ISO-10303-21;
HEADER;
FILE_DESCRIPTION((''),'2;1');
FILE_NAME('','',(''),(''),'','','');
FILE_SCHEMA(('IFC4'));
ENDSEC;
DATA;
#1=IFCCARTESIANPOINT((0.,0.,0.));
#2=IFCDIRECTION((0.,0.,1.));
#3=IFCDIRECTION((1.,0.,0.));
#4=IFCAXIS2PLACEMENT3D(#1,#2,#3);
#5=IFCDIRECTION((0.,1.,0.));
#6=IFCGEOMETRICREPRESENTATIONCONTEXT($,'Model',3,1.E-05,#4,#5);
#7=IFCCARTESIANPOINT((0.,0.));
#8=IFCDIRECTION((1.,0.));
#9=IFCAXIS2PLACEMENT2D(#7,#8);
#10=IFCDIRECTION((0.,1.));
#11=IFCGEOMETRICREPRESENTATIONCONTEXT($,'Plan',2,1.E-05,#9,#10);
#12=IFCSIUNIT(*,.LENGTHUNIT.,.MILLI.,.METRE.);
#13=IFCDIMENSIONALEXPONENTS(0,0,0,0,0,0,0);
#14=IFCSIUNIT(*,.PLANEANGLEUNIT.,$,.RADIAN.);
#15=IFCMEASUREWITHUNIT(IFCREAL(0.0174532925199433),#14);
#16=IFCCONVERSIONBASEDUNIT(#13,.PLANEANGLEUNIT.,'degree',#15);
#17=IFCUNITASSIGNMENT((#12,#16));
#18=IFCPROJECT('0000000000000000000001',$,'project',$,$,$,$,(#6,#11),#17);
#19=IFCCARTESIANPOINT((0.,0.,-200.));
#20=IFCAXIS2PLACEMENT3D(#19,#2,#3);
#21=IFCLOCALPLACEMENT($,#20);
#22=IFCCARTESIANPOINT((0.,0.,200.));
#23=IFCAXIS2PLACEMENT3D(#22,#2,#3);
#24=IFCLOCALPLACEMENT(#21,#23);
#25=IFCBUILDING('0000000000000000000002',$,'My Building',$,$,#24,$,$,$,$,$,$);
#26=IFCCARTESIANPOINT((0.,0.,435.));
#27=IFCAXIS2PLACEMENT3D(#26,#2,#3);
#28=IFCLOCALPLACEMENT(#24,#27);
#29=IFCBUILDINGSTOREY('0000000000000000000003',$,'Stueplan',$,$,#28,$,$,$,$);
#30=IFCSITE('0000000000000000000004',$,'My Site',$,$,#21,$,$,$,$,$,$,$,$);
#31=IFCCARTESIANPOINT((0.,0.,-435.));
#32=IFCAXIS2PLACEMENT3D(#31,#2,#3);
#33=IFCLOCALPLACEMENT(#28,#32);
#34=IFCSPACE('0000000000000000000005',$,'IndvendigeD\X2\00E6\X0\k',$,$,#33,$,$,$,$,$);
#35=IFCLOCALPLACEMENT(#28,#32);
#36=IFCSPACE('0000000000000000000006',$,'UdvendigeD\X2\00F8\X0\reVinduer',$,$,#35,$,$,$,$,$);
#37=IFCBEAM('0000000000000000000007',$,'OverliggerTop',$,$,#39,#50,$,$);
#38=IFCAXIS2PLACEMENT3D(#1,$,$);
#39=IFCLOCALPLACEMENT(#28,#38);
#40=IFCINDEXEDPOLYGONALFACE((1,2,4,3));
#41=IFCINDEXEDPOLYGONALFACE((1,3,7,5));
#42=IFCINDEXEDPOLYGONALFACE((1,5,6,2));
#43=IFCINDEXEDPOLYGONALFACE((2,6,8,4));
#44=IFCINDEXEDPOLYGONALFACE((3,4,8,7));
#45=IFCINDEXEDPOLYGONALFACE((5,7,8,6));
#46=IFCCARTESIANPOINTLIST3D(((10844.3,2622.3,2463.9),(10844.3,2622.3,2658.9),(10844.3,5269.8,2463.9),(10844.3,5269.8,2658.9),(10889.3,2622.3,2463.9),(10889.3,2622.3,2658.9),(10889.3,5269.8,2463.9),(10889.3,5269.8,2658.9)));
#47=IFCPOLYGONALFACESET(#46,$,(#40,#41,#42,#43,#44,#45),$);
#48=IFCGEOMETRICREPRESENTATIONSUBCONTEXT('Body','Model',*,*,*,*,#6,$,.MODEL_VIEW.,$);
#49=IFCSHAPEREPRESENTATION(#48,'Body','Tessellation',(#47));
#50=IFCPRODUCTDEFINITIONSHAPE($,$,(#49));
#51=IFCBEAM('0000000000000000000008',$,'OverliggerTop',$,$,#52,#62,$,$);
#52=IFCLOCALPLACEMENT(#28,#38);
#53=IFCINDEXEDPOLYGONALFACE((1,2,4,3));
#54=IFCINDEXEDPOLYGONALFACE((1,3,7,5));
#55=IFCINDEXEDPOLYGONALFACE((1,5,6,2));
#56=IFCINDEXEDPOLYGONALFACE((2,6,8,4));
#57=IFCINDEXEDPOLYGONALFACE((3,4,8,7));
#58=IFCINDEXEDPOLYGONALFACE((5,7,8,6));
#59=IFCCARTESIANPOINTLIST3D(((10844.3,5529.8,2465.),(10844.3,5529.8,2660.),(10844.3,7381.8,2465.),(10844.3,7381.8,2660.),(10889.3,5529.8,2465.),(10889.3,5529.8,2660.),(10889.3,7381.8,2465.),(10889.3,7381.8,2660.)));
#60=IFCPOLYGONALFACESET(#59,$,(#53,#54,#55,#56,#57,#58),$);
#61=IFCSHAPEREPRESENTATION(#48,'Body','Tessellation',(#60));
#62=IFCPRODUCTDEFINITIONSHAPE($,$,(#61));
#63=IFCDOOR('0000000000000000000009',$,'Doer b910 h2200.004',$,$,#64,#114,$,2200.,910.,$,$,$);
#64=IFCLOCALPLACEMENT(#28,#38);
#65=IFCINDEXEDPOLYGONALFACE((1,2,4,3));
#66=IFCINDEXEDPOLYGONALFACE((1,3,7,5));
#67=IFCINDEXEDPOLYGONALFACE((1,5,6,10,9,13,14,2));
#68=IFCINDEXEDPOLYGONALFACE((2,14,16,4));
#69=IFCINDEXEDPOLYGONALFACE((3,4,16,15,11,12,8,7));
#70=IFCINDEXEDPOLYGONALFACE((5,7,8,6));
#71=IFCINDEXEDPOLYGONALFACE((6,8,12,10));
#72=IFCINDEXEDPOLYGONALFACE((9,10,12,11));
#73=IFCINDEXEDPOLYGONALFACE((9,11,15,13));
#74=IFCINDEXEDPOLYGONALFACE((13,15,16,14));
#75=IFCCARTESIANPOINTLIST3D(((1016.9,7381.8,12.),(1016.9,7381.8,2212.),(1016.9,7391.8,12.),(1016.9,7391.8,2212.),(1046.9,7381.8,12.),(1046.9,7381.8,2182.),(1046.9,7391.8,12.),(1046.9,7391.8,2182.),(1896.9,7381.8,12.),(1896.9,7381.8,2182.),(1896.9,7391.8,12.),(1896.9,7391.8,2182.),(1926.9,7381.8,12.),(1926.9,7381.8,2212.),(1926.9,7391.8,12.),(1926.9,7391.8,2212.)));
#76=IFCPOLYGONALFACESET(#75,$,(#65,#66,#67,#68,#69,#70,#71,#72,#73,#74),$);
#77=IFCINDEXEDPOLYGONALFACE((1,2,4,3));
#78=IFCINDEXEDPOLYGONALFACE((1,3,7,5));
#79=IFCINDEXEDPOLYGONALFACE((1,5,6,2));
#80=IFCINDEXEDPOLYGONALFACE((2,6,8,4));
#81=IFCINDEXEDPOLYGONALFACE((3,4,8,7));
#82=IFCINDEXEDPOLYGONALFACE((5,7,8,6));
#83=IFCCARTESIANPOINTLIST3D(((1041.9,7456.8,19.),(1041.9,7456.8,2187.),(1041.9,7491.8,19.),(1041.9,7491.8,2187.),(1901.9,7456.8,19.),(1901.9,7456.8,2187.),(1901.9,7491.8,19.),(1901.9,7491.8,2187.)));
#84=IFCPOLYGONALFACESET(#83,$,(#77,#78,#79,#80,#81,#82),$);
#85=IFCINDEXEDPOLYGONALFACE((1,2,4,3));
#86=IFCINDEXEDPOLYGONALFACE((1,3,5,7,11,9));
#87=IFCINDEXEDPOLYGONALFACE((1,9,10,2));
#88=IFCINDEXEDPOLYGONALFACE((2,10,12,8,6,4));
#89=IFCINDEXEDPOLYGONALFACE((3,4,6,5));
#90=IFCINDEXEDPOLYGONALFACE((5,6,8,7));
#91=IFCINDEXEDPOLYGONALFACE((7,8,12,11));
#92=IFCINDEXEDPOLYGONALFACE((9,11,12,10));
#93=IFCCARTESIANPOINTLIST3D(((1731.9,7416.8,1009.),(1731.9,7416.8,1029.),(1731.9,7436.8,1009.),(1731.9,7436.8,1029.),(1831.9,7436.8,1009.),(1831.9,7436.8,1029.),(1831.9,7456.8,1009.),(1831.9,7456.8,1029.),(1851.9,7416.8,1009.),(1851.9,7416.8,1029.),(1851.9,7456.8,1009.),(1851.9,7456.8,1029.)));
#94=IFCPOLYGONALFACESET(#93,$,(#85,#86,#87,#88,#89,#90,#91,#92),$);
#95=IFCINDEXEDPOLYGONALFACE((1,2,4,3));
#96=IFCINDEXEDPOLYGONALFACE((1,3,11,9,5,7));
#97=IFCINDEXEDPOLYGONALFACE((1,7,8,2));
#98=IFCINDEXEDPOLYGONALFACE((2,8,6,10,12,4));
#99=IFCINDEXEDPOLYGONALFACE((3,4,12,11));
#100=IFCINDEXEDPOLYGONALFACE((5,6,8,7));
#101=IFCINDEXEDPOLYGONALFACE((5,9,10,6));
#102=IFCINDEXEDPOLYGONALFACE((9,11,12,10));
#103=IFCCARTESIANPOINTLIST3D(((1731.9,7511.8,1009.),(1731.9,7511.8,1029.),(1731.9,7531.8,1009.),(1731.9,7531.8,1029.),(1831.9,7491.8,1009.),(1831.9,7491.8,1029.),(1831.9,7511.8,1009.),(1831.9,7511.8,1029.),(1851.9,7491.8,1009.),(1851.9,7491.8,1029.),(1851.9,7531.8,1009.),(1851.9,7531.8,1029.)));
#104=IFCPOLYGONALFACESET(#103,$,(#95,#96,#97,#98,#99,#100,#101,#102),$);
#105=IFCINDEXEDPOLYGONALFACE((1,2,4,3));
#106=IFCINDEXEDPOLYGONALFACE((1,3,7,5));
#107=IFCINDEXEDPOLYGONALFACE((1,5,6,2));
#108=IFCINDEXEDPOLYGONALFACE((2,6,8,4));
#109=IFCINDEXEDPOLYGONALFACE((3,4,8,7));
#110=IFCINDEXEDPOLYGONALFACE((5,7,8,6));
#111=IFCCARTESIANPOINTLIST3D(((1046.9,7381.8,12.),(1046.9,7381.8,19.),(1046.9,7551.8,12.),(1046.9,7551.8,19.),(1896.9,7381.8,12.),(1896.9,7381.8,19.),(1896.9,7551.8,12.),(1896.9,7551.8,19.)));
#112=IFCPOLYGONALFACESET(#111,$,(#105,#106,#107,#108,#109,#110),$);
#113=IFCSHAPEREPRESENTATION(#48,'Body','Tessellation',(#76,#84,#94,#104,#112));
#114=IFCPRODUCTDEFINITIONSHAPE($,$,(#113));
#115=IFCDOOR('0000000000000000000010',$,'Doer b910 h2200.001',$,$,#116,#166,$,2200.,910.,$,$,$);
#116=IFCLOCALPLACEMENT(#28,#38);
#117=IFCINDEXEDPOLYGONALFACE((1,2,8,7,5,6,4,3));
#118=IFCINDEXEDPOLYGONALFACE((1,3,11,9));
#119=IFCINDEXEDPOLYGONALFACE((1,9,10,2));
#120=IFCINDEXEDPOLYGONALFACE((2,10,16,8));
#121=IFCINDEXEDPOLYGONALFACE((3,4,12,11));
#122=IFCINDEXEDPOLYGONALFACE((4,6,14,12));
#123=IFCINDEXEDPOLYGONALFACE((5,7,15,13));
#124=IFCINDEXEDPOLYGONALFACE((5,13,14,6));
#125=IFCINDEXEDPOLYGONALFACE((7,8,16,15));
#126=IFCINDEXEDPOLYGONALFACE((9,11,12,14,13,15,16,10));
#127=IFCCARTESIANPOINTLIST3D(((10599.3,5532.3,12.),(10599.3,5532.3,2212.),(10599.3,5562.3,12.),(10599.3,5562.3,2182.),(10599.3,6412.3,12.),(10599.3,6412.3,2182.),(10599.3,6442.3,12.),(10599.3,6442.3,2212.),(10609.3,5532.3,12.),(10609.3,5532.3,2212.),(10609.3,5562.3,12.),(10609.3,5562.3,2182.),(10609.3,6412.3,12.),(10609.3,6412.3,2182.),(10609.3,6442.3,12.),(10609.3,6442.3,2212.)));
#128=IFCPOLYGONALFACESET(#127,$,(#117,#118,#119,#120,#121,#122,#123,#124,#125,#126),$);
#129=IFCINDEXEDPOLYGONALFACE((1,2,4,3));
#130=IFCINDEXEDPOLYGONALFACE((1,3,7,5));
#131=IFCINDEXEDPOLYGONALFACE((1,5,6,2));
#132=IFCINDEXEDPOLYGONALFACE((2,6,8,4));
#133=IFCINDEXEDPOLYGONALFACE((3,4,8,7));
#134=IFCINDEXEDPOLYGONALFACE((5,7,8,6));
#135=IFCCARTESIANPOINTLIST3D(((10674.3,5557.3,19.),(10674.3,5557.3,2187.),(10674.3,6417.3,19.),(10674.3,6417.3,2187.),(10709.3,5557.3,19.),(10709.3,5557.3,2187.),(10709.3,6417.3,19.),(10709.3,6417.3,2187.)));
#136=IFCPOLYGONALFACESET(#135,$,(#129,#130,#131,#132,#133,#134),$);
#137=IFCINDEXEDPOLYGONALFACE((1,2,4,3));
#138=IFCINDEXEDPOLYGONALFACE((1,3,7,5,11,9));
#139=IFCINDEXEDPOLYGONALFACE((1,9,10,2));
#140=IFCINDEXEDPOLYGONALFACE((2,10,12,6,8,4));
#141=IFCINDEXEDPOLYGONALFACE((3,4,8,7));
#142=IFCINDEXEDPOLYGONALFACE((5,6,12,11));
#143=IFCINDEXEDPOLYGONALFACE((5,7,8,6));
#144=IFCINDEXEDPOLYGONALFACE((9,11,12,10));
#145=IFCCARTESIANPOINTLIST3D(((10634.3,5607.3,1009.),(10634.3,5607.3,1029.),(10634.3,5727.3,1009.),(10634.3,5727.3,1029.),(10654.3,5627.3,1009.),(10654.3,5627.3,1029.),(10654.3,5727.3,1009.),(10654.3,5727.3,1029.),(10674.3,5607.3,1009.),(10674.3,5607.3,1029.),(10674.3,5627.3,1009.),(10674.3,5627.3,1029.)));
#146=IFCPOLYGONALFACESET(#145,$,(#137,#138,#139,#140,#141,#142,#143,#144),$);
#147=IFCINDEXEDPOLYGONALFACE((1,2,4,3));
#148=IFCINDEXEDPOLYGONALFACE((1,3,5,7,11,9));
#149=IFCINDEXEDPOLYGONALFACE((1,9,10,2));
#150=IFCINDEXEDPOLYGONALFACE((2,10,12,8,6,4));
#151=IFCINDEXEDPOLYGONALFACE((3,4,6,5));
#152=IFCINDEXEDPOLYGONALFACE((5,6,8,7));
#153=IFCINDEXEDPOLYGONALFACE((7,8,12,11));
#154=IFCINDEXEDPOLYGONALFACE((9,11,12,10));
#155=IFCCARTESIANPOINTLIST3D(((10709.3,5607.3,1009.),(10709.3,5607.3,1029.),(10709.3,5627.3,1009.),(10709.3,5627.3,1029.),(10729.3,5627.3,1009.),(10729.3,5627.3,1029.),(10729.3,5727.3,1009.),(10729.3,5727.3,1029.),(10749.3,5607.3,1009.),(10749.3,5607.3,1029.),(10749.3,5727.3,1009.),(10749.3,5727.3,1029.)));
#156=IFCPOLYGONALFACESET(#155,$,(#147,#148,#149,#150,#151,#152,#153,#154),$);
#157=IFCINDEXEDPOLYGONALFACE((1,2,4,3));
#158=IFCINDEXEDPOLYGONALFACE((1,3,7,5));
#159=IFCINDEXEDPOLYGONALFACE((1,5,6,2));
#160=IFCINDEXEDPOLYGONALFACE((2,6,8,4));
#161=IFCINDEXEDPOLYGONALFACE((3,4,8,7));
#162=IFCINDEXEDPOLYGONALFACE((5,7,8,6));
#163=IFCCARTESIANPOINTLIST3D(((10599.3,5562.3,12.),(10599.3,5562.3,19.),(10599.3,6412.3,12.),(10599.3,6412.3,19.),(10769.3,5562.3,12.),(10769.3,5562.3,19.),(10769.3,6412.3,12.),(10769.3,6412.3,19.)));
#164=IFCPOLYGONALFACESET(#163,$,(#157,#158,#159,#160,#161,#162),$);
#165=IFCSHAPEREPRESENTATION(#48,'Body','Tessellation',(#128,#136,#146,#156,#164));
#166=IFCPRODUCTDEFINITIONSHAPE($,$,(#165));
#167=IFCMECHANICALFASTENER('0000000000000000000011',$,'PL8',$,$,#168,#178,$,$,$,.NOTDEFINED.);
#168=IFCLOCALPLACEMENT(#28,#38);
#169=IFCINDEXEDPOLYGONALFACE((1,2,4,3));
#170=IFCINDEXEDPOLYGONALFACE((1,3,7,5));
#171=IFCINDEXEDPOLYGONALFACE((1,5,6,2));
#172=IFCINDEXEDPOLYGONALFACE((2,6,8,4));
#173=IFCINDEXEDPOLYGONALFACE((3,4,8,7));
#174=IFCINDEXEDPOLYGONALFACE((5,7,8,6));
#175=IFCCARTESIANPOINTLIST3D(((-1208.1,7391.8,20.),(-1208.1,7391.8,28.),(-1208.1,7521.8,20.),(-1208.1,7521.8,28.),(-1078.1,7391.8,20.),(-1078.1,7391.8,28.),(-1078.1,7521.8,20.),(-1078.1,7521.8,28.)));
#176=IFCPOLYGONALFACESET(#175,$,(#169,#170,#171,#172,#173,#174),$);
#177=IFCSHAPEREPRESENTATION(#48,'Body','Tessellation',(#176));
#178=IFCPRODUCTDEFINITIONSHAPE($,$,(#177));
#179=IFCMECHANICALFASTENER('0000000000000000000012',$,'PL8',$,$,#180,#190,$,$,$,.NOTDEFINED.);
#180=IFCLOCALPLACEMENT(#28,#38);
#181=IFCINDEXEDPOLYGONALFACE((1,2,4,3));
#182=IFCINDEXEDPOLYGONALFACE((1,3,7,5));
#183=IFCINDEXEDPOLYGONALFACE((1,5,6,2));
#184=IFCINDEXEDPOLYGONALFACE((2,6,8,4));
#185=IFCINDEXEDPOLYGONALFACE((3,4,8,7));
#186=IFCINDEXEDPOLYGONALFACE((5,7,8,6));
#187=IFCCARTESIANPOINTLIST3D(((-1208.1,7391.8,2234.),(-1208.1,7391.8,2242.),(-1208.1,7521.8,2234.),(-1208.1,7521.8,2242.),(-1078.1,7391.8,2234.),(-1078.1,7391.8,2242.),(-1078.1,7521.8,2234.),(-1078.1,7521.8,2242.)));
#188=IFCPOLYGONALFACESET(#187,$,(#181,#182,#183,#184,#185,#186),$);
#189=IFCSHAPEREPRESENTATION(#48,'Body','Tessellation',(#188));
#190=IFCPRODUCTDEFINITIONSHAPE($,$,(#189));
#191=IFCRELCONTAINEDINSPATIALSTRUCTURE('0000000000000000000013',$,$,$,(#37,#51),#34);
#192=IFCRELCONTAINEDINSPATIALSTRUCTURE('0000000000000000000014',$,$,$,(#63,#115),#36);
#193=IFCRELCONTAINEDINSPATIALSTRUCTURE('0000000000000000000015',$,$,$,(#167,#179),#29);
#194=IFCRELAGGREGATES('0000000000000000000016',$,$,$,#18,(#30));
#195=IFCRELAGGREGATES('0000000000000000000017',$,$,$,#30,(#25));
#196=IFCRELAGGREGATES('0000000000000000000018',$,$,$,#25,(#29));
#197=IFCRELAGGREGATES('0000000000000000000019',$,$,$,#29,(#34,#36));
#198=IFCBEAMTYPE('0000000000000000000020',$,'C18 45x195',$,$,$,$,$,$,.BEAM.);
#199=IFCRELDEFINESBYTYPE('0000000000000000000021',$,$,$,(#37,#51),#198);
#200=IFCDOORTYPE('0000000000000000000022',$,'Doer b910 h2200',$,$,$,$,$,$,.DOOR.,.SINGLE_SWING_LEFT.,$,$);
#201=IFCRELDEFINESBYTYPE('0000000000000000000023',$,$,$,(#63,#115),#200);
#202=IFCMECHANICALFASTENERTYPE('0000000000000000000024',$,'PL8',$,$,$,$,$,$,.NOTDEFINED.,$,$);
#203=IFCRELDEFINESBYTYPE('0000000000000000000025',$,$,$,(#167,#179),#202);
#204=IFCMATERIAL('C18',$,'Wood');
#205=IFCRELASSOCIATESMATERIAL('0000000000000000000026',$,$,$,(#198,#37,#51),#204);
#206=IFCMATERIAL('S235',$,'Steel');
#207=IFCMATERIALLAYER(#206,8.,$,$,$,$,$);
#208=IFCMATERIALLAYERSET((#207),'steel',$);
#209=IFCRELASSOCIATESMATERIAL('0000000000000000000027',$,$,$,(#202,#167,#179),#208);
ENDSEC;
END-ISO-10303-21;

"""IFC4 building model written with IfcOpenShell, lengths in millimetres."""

from ifc_helpers import new_model, entity, si_unit, converted_unit, direction, frame, origin_with_axes, origin_2d_with_axis, place, context, subcontext, project, spatial, line, indexed_curve, rectangle, outline, extrude, shape, source, transform, mapped, material, layer, layer_set, layer_usage, material_profile, profile_set, profile_usage, type_object, type_shapes, element, save


model = new_model("IFC4")

# Units and contexts
model_context = context("Model", 3, precision=1e-05, world=origin_with_axes(), true_north=direction((0.0, 1.0, 0.0)))
plan_context = context("Plan", 2, precision=1e-05, world=origin_2d_with_axis(), true_north=direction((0.0, 1.0)))
body_context_1 = subcontext(model_context, "Body", "Model", "MODEL_VIEW")
body_context_2 = subcontext(plan_context, "Body", "Plan", "PLAN_VIEW")
ifc_project = project(units=[si_unit("LENGTHUNIT", "METRE", prefix="MILLI"), converted_unit("PLANEANGLEUNIT", "degree", entity("IfcReal", 0.0174532925199433), si_unit("PLANEANGLEUNIT", "RADIAN"), dimensions=[0, 0, 0, 0, 0, 0, 0])], contexts=[model_context, plan_context])

# Site, building, storey
site_placement = place(None, frame((0.0, 0.0, -200.0), z_axis=(0.0, 0.0, 1.0), x_axis=(1.0, 0.0, 0.0)))
site = spatial("IfcSite", under=ifc_project, at=site_placement, Name="My Site")
building_placement = place(site_placement, frame((0.0, 0.0, 200.0), z_axis=(0.0, 0.0, 1.0), x_axis=(1.0, 0.0, 0.0)))
building = spatial("IfcBuilding", under=site, at=building_placement, Name="My Building")
storey_placement = place(building_placement, frame((0.0, 0.0, 435.0), z_axis=(0.0, 0.0, 1.0), x_axis=(1.0, 0.0, 0.0)))
storey = spatial("IfcBuildingStorey", under=building, at=storey_placement, Name="Stueplan")

# Shared definitions
ifc_material_1 = material(Name="C18", Category="Wood")
ifc_material_2 = material(Name="S235", Category="Steel")

# Shared definitions
ifc_material_profile_1 = material_profile(ifc_material_1, rectangle(XDim=45.0, YDim=195.0))
ifc_profile_set_1 = profile_set([ifc_material_profile_1], Name="woodStructural")
beam_type_1 = type_object("IfcBeamType", Name="C18 45x195", PredefinedType="BEAM", material=ifc_profile_set_1)

# Shared definitions
space_1_placement = place(storey_placement, frame((0.0, 0.0, -435.0), z_axis=(0.0, 0.0, 1.0), x_axis=(1.0, 0.0, 0.0)))
space_1 = spatial("IfcSpace", under=storey, at=space_1_placement, Name="IndvendigeDæk")

# Beams
ifc_profile_usage_1 = profile_usage(ifc_profile_set_1)
beam_1_placement = place(space_1_placement, frame((10866.8, 5269.8, 2996.4), z_axis=(0.000001, -1.0, 0.0), x_axis=(-1.0, -0.000001, 0.0)))
element("IfcBeam", 1, at=beam_1_placement, inside=space_1, type_object=beam_type_1, material=ifc_profile_usage_1, Name="OverliggerTop", context=body_context_1, shape_type="SweptSolid", body=[
    extrude(rectangle(XDim=45.0, YDim=195.0), origin_with_axes(), (0.0, 0.0, 1.0), 2647.5),
])
ifc_profile_usage_2 = profile_usage(ifc_profile_set_1)
beam_2_placement = place(space_1_placement, frame((10866.8, 7381.8, 2997.5), z_axis=(0.000001, -1.0, 0.0), x_axis=(-1.0, -0.000001, 0.0)))
element("IfcBeam", 2, at=beam_2_placement, inside=space_1, type_object=beam_type_1, material=ifc_profile_usage_2, Name="OverliggerTop", context=body_context_1, shape_type="SweptSolid", body=[
    extrude(rectangle(XDim=45.0, YDim=195.0), origin_with_axes(), (0.0, 0.0, 1.0), 1852.0),
])

# Shared definitions
space_2_placement = place(storey_placement, frame((0.0, 0.0, -435.0), z_axis=(0.0, 0.0, 1.0), x_axis=(1.0, 0.0, 0.0)))
space_2 = spatial("IfcSpace", under=storey, at=space_2_placement, Name="UdvendigeDøreVinduer")

# Doors
door_type = type_object("IfcDoorType", Name="Doer b910 h2200", OperationType="SINGLE_SWING_LEFT", PredefinedType="DOOR")
shared_shape_1 = source(origin_with_axes(), body_context_1, "Body", "SweptSolid", [
    extrude(outline(indexed_curve([(0.0, 0.0), (0.0, 2200.0), (910.0, 2200.0), (910.0, 0.0), (880.0, 0.0), (880.0, 2170.0), (30.0, 2170.0), (30.0, 0.0)], segments=[line(1, 2, 3, 4, 5, 6, 7, 8, 1)])), frame((0.0, 0.0, 0.0), z_axis=(0.0, -1.0, 0.0), x_axis=(1.0, 0.0, 0.0)), (0.0, 0.0, -1.0), 10.0),
    extrude(outline(indexed_curve([(0.0, 0.0), (860.0, 0.0), (860.0, 35.0), (0.0, 35.0)], segments=[line(1, 2, 3, 4, 1)])), frame((25.0, 75.0, 7.0), z_axis=(0.0, 0.0, 1.0), x_axis=(1.0, 0.0, 0.0)), (0.0, 0.0, 1.0), 2168.0),
    extrude(outline(indexed_curve([(0.0, 0.0), (0.0, -40.0), (-120.0, -40.0), (-120.0, -20.0), (-20.0, -20.0), (-20.0, 0.0)], segments=[line(1, 2, 3, 4, 5, 6, 1)])), frame((835.0, 75.0, 997.0), z_axis=(0.0, 0.0, 1.0), x_axis=(1.0, 0.0, 0.0)), (0.0, 0.0, 1.0), 20.0),
    extrude(outline(indexed_curve([(0.0, 0.0), (0.0, 40.0), (-120.0, 40.0), (-120.0, 20.0), (-20.0, 20.0), (-20.0, 0.0)], segments=[line(1, 2, 3, 4, 5, 6, 1)])), frame((835.0, 110.0, 997.0), z_axis=(0.0, 0.0, 1.0), x_axis=(1.0, 0.0, 0.0)), (0.0, 0.0, 1.0), 20.0),
    extrude(outline(indexed_curve([(0.0, 0.0), (850.0, 0.0), (850.0, 170.0), (0.0, 170.0)], segments=[line(1, 2, 3, 4, 1)])), frame((30.0, 0.0, 0.0), z_axis=(0.0, 0.0, 1.0), x_axis=(1.0, 0.0, 0.0)), (0.0, 0.0, 1.0), 7.0),
])
shared_shape_2 = source(origin_with_axes(), body_context_2, "Body", "Curve2D", [
    entity("IfcIndexedPolyCurve", entity("IfcCartesianPointList2D", [[0.0, 0.0], [30.0, 0.0], [30.0, 10.0], [0.0, 10.0]]), [entity("IfcLineIndex", [1, 2, 3, 4, 1])]),
    entity("IfcIndexedPolyCurve", entity("IfcCartesianPointList2D", [[910.0, 0.0], [880.0, 0.0], [880.0, 10.0], [910.0, 10.0]]), [entity("IfcLineIndex", [1, 2, 3, 4, 1])]),
    entity("IfcTrimmedCurve", entity("IfcEllipse", entity("IfcAxis2Placement2D", entity("IfcCartesianPoint", [60.0, 10.0]), entity("IfcDirection", [1.0, 0.0])), 825.0, 860.0), [entity("IfcCartesianPoint", [885.0, 10.0])], [entity("IfcCartesianPoint", [60.0, 870.0])], True, "CARTESIAN"),
    entity("IfcIndexedPolyCurve", entity("IfcCartesianPointList2D", [[25.0, 10.0], [60.0, 10.0], [60.0, 870.0], [25.0, 870.0]]), [entity("IfcLineIndex", [1, 2, 3, 4, 1])]),
])
type_shapes(door_type, [shared_shape_1, shared_shape_2])
placement_1 = place(storey_placement, frame((0.0, 0.0, -435.0), z_axis=(0.0, 0.0, 1.0), x_axis=(1.0, 0.0, 0.0)))
placement_2 = place(placement_1, frame((10599.3, 7381.5, 447.0), z_axis=(0.0, 0.0, 1.0), x_axis=(-1.0, 0.0, 0.0)))
placement_3 = place(placement_2, frame((9582.4, -0.3, 0.0), z_axis=(0.0, 0.0, 1.0), x_axis=(-1.0, 0.0, 0.0)))
door_1_placement = place(placement_3, frame((0.0, 0.0, 0.0), z_axis=(0.0, 0.0, 1.0), x_axis=(1.0, 0.0, 0.0)))
element("IfcDoor", 3, at=door_1_placement, inside=space_2, type_object=door_type, Name="Doer b910 h2200.004", OverallHeight=2200.0, OverallWidth=910.0, shapes=[
    shape(body_context_1, "Body", "MappedRepresentation", [mapped(shared_shape_1, transform((0.0, 0.0, 0.0), x_axis=(1.0, 0.0, 0.0), y_axis=(0.0, 1.0, 0.0), z_axis=(0.0, 0.0, 1.0), scale=1.0))]),
    shape(body_context_2, "Body", "MappedRepresentation", [mapped(shared_shape_2, transform((0.0, 0.0, 0.0), x_axis=(1.0, 0.0, 0.0), y_axis=(0.0, 1.0, 0.0), z_axis=(0.0, 0.0, 1.0), scale=1.0))]),
])
placement_4 = place(placement_1, frame((10599.3, -5297.5, 435.0), z_axis=(0.0, 0.0, 1.0), x_axis=(0.000001, 1.0, 0.0)))
placement_5 = place(placement_4, frame((11739.8, 0.0, 12.0), z_axis=(0.0, 0.0, 1.0), x_axis=(-1.0, 0.0, 0.0)))
door_2_placement = place(placement_5, frame((0.0, 0.0, 0.0), z_axis=(0.0, 0.0, 1.0), x_axis=(1.0, 0.0, 0.0)))
element("IfcDoor", 4, at=door_2_placement, inside=space_2, type_object=door_type, Name="Doer b910 h2200.001", OverallHeight=2200.0, OverallWidth=910.0, shapes=[
    shape(body_context_1, "Body", "MappedRepresentation", [mapped(shared_shape_1, transform((0.0, 0.0, 0.0), x_axis=(1.0, 0.0, 0.0), y_axis=(0.0, 1.0, 0.0), z_axis=(0.0, 0.0, 1.0), scale=1.0))]),
    shape(body_context_2, "Body", "MappedRepresentation", [mapped(shared_shape_2, transform((0.0, 0.0, 0.0), x_axis=(1.0, 0.0, 0.0), y_axis=(0.0, 1.0, 0.0), z_axis=(0.0, 0.0, 1.0), scale=1.0))]),
])

# Mechanical fasteners
ifc_layer_1 = layer(ifc_material_2, 8.0)
ifc_layer_set_1 = layer_set([ifc_layer_1], Name="steel")
ifc_layer_usage_1 = layer_usage(ifc_layer_set_1, "AXIS3", "POSITIVE", 0.0)
mechanical_fastener_type_1 = type_object("IfcMechanicalFastenerType", Name="PL8", PredefinedType="NOTDEFINED", material=ifc_layer_set_1)
mechanical_fastener_1_placement = place(storey_placement, frame((-1208.1, 7391.8, 20.0), z_axis=(0.0, 0.0, 1.0), x_axis=(1.0, 0.0, 0.0)))
element("IfcMechanicalFastener", 5, at=mechanical_fastener_1_placement, inside=storey, type_object=mechanical_fastener_type_1, material=ifc_layer_usage_1, Name="PL8", PredefinedType="NOTDEFINED", context=body_context_1, shape_type="SweptSolid", body=[
    extrude(outline(indexed_curve([(0.0, 130.0), (0.0, 0.0), (130.0, 0.0), (130.0, 130.0), (0.0, 130.0)])), None, (0.0, 0.0, 1.0), 8.0),
])
ifc_layer_usage_2 = layer_usage(ifc_layer_set_1, "AXIS3", "POSITIVE", 0.0)
mechanical_fastener_2_placement = place(storey_placement, frame((-1208.1, 7391.8, 2234.0), z_axis=(0.0, 0.0, 1.0), x_axis=(1.0, 0.0, 0.0)))
element("IfcMechanicalFastener", 6, at=mechanical_fastener_2_placement, inside=storey, type_object=mechanical_fastener_type_1, material=ifc_layer_usage_2, Name="PL8", PredefinedType="NOTDEFINED", context=body_context_1, shape_type="SweptSolid", body=[
    extrude(outline(indexed_curve([(0.0, 130.0), (0.0, 0.0), (130.0, 0.0), (130.0, 130.0), (0.0, 130.0)])), None, (0.0, 0.0, 1.0), 8.0),
])

save(model, "model.ifc")
